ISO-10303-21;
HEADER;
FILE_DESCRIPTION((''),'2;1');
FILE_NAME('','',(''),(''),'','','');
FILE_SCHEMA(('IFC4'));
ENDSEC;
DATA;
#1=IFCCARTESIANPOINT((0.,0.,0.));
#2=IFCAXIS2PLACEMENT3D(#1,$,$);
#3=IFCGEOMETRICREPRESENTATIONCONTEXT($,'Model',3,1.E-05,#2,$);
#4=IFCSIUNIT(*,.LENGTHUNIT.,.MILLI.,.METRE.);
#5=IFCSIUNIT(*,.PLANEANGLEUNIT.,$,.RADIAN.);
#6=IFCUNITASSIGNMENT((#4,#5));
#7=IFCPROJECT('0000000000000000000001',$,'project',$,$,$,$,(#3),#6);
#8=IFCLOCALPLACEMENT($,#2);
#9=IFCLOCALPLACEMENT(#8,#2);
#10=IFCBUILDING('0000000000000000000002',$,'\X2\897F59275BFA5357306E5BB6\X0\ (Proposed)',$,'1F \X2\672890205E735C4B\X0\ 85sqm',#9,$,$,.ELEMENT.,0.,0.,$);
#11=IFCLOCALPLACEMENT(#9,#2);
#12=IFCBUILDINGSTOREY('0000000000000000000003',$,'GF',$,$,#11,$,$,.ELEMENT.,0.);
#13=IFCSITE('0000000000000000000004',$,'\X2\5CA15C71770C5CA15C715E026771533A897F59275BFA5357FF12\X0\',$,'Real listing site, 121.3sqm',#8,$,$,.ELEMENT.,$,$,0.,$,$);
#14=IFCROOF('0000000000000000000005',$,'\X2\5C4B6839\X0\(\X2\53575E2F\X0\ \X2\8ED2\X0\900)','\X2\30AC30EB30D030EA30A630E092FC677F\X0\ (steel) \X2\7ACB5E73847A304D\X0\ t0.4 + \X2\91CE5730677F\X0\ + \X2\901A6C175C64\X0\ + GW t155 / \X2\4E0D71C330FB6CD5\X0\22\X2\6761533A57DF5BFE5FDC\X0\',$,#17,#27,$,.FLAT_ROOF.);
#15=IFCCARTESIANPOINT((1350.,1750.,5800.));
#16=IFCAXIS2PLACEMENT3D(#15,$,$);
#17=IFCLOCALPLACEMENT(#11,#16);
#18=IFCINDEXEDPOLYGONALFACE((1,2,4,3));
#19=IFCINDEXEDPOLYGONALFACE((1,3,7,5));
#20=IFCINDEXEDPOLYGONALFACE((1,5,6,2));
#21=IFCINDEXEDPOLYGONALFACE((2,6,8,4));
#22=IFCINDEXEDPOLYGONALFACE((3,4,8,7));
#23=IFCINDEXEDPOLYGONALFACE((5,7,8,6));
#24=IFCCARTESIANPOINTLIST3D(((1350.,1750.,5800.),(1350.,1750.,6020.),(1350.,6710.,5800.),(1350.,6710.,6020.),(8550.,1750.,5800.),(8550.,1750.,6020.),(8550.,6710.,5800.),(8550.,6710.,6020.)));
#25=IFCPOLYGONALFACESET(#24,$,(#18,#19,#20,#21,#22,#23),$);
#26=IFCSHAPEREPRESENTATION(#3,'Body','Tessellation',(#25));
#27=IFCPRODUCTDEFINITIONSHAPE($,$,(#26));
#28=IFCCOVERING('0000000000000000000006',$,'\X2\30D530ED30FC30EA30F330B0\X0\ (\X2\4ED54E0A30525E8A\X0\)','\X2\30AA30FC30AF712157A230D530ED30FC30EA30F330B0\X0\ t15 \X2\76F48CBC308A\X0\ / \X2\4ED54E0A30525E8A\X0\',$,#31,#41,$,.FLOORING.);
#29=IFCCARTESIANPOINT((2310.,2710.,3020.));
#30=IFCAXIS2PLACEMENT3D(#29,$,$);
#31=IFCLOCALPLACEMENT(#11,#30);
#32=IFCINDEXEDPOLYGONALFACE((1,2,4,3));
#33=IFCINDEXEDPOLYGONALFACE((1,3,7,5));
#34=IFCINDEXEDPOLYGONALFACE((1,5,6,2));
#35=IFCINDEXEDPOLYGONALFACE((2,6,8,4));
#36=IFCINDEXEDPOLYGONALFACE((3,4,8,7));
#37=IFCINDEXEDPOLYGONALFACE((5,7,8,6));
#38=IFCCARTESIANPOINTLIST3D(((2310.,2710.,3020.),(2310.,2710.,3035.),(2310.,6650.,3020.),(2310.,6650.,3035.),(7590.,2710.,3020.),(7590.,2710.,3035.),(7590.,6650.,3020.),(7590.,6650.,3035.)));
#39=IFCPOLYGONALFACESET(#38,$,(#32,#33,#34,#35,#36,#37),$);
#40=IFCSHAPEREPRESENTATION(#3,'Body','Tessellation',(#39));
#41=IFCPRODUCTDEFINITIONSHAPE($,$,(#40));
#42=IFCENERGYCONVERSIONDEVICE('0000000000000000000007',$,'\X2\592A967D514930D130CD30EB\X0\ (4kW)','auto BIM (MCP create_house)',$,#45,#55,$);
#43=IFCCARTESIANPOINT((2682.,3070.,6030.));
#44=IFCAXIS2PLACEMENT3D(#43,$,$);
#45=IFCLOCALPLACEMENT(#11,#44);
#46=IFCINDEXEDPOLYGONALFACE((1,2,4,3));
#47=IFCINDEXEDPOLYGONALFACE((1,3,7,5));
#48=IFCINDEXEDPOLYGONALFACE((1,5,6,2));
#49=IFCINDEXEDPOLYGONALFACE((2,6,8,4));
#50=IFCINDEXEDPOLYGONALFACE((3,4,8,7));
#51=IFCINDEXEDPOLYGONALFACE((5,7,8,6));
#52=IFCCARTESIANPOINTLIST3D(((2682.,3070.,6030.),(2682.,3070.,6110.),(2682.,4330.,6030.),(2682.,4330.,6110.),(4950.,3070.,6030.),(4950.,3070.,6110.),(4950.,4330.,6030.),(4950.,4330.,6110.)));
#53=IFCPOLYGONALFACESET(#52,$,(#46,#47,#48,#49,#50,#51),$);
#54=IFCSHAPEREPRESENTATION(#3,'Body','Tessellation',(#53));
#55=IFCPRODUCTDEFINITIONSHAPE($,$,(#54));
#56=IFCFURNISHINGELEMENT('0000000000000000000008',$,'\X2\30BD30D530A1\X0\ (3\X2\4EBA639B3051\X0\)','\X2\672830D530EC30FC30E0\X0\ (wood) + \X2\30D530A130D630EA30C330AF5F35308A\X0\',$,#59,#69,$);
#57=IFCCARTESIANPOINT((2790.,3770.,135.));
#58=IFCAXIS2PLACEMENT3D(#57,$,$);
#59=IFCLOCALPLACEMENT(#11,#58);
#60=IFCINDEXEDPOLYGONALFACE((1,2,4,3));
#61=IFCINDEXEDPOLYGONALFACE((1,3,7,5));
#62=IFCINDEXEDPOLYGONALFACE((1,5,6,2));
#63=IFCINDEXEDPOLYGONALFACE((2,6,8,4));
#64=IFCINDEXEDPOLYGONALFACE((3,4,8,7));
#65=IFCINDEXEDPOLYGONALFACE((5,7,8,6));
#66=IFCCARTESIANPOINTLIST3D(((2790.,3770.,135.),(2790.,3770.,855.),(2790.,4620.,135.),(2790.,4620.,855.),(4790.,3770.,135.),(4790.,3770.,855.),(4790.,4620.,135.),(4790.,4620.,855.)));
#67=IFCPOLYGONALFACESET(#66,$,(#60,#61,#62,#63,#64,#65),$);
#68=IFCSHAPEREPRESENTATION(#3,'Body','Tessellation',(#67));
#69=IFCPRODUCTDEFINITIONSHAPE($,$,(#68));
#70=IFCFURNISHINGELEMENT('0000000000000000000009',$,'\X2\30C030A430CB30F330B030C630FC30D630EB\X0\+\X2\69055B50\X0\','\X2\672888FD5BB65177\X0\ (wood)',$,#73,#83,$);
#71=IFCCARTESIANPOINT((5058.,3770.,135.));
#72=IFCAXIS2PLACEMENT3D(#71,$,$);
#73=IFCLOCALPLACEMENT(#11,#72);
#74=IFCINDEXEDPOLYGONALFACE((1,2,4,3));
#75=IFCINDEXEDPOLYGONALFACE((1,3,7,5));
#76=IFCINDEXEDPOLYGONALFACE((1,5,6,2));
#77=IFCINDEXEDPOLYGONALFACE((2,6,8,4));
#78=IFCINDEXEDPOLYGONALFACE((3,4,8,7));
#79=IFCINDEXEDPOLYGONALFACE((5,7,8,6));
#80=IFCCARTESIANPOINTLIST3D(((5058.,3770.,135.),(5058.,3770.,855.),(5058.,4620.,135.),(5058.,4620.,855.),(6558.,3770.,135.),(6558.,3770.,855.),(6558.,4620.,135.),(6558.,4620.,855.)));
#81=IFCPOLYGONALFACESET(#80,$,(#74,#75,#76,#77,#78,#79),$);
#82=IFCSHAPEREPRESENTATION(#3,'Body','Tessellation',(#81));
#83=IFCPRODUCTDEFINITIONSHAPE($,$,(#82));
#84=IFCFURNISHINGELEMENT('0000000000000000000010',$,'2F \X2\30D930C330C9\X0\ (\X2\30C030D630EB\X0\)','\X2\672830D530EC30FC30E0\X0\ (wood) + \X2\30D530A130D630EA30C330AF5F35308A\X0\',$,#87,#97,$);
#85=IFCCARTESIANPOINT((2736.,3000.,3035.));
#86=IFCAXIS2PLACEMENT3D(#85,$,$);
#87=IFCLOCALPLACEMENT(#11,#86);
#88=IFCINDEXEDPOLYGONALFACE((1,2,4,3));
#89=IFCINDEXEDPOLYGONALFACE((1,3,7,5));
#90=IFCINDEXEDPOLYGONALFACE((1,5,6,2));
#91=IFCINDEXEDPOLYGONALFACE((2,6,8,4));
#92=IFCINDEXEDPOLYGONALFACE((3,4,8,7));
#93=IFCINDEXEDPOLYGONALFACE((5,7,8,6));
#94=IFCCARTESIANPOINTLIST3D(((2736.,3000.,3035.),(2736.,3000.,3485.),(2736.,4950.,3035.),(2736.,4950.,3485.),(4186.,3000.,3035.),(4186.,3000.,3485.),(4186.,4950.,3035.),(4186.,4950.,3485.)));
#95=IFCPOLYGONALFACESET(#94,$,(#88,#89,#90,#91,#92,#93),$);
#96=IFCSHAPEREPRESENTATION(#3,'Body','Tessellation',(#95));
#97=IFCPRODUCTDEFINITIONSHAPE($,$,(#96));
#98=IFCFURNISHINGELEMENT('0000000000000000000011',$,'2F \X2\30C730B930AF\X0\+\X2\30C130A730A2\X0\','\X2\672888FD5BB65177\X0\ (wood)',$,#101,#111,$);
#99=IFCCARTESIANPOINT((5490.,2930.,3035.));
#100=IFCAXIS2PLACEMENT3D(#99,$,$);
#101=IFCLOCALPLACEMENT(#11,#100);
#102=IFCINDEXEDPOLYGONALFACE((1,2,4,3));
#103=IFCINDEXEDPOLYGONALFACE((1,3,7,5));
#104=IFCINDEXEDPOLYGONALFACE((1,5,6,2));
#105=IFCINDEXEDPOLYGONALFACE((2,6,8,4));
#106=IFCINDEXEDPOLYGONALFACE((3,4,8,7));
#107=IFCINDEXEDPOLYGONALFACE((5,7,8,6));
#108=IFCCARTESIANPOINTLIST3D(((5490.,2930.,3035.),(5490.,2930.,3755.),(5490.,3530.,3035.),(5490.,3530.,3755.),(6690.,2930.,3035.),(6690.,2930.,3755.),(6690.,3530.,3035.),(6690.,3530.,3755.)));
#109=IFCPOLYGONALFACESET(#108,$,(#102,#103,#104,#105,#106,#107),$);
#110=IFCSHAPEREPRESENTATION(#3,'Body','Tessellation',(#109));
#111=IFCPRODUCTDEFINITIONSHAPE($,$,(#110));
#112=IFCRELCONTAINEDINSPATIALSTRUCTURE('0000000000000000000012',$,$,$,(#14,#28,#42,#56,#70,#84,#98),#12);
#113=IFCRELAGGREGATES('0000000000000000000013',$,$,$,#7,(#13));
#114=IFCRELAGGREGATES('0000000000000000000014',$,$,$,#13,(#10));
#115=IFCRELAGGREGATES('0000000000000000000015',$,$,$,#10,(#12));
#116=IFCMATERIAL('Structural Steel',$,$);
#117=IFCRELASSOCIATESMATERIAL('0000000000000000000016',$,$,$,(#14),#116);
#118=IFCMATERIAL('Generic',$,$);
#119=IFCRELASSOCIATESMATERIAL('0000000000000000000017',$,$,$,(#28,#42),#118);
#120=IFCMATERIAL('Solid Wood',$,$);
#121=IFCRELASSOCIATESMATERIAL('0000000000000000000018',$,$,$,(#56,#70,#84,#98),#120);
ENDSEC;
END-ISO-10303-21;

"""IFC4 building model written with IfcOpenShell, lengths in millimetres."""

from ifc_helpers import new_model, si_unit, frame, frame_2d, origin, place, context, project, spatial, rectangle, extrude, material, element, save


model = new_model("IFC4")

# Units and contexts
model_context = context("Model", 3, precision=1e-05, world=origin())
ifc_project = project(units=[si_unit("LENGTHUNIT", "METRE", prefix="MILLI"), si_unit("PLANEANGLEUNIT", "RADIAN")], contexts=[model_context])

# Site, building, storey
site_placement = place(None, origin())
site = spatial("IfcSite", under=ifc_project, at=site_placement, Name="岡山県岡山市東区西大寺南２", ObjectType="Real listing site, 121.3sqm", CompositionType="ELEMENT", RefElevation=0.0)
building_placement = place(site_placement, origin())
building = spatial("IfcBuilding", under=site, at=building_placement, Name="西大寺南の家 (Proposed)", ObjectType="1F 木造平屋 85sqm", CompositionType="ELEMENT", ElevationOfRefHeight=0.0, ElevationOfTerrain=0.0)
storey_placement = place(building_placement, origin())
storey = spatial("IfcBuildingStorey", under=building, at=storey_placement, Name="GF", CompositionType="ELEMENT", Elevation=0.0)

# Shared definitions
ifc_material_1 = material(Name="Solid Wood")

# Shared definitions
ifc_material_2 = material(Name="Generic")

# Roof
ifc_material_3 = material(Name="Structural Steel")
for number, where, name in (
    (1, (1350.0, 1750.0, 5800.0), "屋根(南帯 軒900)"),
):
    element("IfcRoof", number, at=place(storey_placement, frame(where)), inside=storey, material=ifc_material_3, Name=name, Description="ガルバリウム鋼板 (steel) 立平葺き t0.4 + 野地板 + 通気層 + GW t155 / 不燃・法22条区域対応", PredefinedType="FLAT_ROOF", context=model_context, shape_type="SweptSolid", body=[
        extrude(rectangle(XDim=7200.0, YDim=4960.0, at=frame_2d((3600.0, 2480.0))), frame((1350.0, 1750.0, 5800.0)), (0.0, 0.0, 1.0), 220.0),
    ])

# Covering
covering_placement = place(storey_placement, frame((2310.0, 2710.0, 3020.0)))
element("IfcCovering", 2, at=covering_placement, inside=storey, material=ifc_material_2, Name="フローリング (仕上げ床)", Description="オーク無垢フローリング t15 直貼り / 仕上げ床", PredefinedType="FLOORING", context=model_context, shape_type="SweptSolid", body=[
    extrude(rectangle(XDim=5280.0, YDim=3940.0, at=frame_2d((2640.0, 1970.0))), frame((2310.0, 2710.0, 3020.0)), (0.0, 0.0, 1.0), 15.0),
])

# Energy conversion device
energy_conversion_device_placement = place(storey_placement, frame((2682.0, 3070.0, 6030.0)))
element("IfcEnergyConversionDevice", 3, at=energy_conversion_device_placement, inside=storey, material=ifc_material_2, Name="太陽光パネル (4kW)", Description="auto BIM (MCP create_house)", context=model_context, shape_type="SweptSolid", body=[
    extrude(rectangle(XDim=2268.0, YDim=1260.0, at=frame_2d((1134.0, 630.0))), frame((2682.0, 3070.0, 6030.0)), (0.0, 0.0, 1.0), 80.0),
])

# Furnishing elements
furnishing_1_placement = place(storey_placement, frame((2790.0, 3770.0, 135.0)))
element("IfcFurnishingElement", 4, at=furnishing_1_placement, inside=storey, material=ifc_material_1, Name="ソファ (3人掛け)", Description="木フレーム (wood) + ファブリック張り", context=model_context, shape_type="SweptSolid", body=[
    extrude(rectangle(XDim=2000.0, YDim=850.0, at=frame_2d((1000.0, 425.0))), frame((2790.0, 3770.0, 135.0)), (0.0, 0.0, 1.0), 720.0),
])
furnishing_2_placement = place(storey_placement, frame((5058.0, 3770.0, 135.0)))
element("IfcFurnishingElement", 5, at=furnishing_2_placement, inside=storey, material=ifc_material_1, Name="ダイニングテーブル+椅子", Description="木製家具 (wood)", context=model_context, shape_type="SweptSolid", body=[
    extrude(rectangle(XDim=1500.0, YDim=850.0, at=frame_2d((750.0, 425.0))), frame((5058.0, 3770.0, 135.0)), (0.0, 0.0, 1.0), 720.0),
])
furnishing_3_placement = place(storey_placement, frame((2736.0, 3000.0, 3035.0)))
element("IfcFurnishingElement", 6, at=furnishing_3_placement, inside=storey, material=ifc_material_1, Name="2F ベッド (ダブル)", Description="木フレーム (wood) + ファブリック張り", context=model_context, shape_type="SweptSolid", body=[
    extrude(rectangle(XDim=1450.0, YDim=1950.0, at=frame_2d((725.0, 975.0))), frame((2736.0, 3000.0, 3035.0)), (0.0, 0.0, 1.0), 450.0),
])
furnishing_4_placement = place(storey_placement, frame((5490.0, 2930.0, 3035.0)))
element("IfcFurnishingElement", 7, at=furnishing_4_placement, inside=storey, material=ifc_material_1, Name="2F デスク+チェア", Description="木製家具 (wood)", context=model_context, shape_type="SweptSolid", body=[
    extrude(rectangle(XDim=1200.0, YDim=600.0, at=frame_2d((600.0, 300.0))), frame((5490.0, 2930.0, 3035.0)), (0.0, 0.0, 1.0), 720.0),
])

save(model, "model.ifc")
